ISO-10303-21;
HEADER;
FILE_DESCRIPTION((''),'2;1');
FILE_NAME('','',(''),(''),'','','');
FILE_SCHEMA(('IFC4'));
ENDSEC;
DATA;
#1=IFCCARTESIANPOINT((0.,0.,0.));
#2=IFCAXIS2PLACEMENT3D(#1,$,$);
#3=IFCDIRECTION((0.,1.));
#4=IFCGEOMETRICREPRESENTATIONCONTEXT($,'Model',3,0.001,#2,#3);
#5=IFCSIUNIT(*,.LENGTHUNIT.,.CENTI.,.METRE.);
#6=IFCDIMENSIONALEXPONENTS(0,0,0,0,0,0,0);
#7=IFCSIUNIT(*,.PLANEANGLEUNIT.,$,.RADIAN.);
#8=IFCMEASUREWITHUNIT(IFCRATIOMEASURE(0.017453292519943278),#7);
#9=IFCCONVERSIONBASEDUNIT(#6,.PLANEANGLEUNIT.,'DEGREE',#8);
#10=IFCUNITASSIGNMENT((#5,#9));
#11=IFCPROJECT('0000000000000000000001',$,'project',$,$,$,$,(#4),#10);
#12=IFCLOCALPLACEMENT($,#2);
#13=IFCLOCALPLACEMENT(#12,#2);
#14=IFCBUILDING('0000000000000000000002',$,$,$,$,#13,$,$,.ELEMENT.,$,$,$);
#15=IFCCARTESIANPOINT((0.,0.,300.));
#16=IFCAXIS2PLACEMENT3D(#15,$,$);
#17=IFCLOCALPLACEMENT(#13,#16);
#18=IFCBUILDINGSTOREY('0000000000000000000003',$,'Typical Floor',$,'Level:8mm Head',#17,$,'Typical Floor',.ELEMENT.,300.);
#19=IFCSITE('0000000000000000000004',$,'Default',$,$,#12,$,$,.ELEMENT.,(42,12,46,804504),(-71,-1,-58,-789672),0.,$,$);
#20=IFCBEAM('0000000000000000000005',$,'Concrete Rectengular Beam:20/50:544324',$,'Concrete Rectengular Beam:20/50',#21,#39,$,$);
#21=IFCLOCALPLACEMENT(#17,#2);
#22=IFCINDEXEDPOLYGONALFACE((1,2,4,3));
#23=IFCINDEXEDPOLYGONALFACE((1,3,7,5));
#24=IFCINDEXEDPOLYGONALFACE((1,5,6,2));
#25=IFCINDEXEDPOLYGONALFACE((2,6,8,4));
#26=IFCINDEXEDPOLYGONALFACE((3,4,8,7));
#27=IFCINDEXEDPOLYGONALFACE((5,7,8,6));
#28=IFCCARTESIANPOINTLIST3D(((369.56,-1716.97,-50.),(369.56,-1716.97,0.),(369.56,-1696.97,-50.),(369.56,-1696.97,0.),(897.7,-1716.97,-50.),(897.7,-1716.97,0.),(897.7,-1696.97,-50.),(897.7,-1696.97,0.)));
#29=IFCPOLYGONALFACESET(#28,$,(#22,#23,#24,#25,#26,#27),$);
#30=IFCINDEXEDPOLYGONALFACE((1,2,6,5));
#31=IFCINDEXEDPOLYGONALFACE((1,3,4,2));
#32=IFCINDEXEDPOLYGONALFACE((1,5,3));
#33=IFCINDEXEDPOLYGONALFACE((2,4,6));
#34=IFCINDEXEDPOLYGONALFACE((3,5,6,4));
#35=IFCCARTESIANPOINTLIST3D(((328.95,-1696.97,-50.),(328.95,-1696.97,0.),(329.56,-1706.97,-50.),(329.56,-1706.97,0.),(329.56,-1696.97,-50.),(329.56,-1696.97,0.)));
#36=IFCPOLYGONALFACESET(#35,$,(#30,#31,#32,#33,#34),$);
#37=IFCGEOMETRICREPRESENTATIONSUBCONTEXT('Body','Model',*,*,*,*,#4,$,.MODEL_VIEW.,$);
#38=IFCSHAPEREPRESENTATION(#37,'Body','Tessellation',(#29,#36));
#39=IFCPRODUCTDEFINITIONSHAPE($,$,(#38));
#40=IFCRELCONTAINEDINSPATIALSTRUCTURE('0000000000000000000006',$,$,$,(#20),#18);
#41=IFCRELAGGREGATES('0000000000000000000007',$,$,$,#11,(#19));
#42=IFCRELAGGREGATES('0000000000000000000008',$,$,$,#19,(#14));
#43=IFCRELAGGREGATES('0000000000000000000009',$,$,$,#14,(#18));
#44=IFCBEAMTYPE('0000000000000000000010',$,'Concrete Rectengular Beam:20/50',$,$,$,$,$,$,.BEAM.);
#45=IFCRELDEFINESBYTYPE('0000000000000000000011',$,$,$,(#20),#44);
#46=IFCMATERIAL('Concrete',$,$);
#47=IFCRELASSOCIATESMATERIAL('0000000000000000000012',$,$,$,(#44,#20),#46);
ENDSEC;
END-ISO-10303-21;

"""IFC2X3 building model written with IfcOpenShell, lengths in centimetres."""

from ifc_helpers import new_model, entity, si_unit, converted_unit, direction, frame, frame_2d, origin, place, context, subcontext, project, spatial, rectangle, extrude, clip, halfspace, source, transform, mapped, material, type_object, type_shapes, element, save


model = new_model("IFC2X3")

# Units and contexts
model_context = context("Model", 3, precision=0.001, world=origin(), true_north=direction((0.0, 1.0)))
body_context = subcontext(model_context, "Body", "Model", "MODEL_VIEW")
ifc_project = project(units=[si_unit("LENGTHUNIT", "METRE", prefix="CENTI"), converted_unit("PLANEANGLEUNIT", "DEGREE", entity("IfcRatioMeasure", 0.017453292519943278), si_unit("PLANEANGLEUNIT", "RADIAN"), dimensions=[0, 0, 0, 0, 0, 0, 0])], contexts=[model_context])

# Site, building, storey
site_placement = place(None, origin())
site = spatial("IfcSite", under=ifc_project, at=site_placement, Name="Default", CompositionType="ELEMENT", RefLatitude=(42, 12, 46, 804504), RefLongitude=(-71, -1, -58, -789672), RefElevation=0.0)
building_placement = place(site_placement, origin())
building = spatial("IfcBuilding", under=site, at=building_placement, CompositionType="ELEMENT")
storey_placement = place(building_placement, frame((0.0, 0.0, 300.0)))
storey = spatial("IfcBuildingStorey", under=building, at=storey_placement, Name="Typical Floor", ObjectType="Level:8mm Head", LongName="Typical Floor", CompositionType="ELEMENT", Elevation=300.0)

# Beam
ifc_material = material(Name="Concrete")
beam_type_1 = type_object("IfcBeamType", Name="Concrete Rectengular Beam:20/50", PredefinedType="BEAM", material=ifc_material)
shared_shape_1 = source(origin(), body_context, "Body", "SweptSolid", [
    extrude(rectangle(XDim=50.0, YDim=20.0, at=frame_2d((0.0, 0.0), x_axis=(1.0, 0.0))), frame((897.7, -1706.97, 275.0), z_axis=(-1.0, 0.0, 0.0), x_axis=(0.0, 0.0, -1.0)), (0.0, 0.0, 1.0), 528.14),
    clip(extrude(rectangle(XDim=50.0, YDim=10.0, at=frame_2d((0.0, 0.0), x_axis=(1.0, 0.0))), frame((329.56, -1701.97, 275.0), z_axis=(-1.0, 0.0, 0.0), x_axis=(0.0, 0.0, -1.0)), (0.0, 0.0, 1.0), 0.61), halfspace(frame((330.17, -1716.97, 300.0), z_axis=(-0.998135, -0.061049, 0.0), x_axis=(0.061049, -0.998135, 0.0)), False)),
])
type_shapes(beam_type_1, [shared_shape_1])
beam_1_placement = place(storey_placement, frame((0.0, 0.0, -300.0)))
element("IfcBeam", 1, at=beam_1_placement, inside=storey, type_object=beam_type_1, material=ifc_material, Name="Concrete Rectengular Beam:20/50:544324", ObjectType="Concrete Rectengular Beam:20/50", context=body_context, shape_type="MappedRepresentation", body=[
    mapped(shared_shape_1, transform((0.0, 0.0, 0.0), scale=1.0)),
])

save(model, "model.ifc")
